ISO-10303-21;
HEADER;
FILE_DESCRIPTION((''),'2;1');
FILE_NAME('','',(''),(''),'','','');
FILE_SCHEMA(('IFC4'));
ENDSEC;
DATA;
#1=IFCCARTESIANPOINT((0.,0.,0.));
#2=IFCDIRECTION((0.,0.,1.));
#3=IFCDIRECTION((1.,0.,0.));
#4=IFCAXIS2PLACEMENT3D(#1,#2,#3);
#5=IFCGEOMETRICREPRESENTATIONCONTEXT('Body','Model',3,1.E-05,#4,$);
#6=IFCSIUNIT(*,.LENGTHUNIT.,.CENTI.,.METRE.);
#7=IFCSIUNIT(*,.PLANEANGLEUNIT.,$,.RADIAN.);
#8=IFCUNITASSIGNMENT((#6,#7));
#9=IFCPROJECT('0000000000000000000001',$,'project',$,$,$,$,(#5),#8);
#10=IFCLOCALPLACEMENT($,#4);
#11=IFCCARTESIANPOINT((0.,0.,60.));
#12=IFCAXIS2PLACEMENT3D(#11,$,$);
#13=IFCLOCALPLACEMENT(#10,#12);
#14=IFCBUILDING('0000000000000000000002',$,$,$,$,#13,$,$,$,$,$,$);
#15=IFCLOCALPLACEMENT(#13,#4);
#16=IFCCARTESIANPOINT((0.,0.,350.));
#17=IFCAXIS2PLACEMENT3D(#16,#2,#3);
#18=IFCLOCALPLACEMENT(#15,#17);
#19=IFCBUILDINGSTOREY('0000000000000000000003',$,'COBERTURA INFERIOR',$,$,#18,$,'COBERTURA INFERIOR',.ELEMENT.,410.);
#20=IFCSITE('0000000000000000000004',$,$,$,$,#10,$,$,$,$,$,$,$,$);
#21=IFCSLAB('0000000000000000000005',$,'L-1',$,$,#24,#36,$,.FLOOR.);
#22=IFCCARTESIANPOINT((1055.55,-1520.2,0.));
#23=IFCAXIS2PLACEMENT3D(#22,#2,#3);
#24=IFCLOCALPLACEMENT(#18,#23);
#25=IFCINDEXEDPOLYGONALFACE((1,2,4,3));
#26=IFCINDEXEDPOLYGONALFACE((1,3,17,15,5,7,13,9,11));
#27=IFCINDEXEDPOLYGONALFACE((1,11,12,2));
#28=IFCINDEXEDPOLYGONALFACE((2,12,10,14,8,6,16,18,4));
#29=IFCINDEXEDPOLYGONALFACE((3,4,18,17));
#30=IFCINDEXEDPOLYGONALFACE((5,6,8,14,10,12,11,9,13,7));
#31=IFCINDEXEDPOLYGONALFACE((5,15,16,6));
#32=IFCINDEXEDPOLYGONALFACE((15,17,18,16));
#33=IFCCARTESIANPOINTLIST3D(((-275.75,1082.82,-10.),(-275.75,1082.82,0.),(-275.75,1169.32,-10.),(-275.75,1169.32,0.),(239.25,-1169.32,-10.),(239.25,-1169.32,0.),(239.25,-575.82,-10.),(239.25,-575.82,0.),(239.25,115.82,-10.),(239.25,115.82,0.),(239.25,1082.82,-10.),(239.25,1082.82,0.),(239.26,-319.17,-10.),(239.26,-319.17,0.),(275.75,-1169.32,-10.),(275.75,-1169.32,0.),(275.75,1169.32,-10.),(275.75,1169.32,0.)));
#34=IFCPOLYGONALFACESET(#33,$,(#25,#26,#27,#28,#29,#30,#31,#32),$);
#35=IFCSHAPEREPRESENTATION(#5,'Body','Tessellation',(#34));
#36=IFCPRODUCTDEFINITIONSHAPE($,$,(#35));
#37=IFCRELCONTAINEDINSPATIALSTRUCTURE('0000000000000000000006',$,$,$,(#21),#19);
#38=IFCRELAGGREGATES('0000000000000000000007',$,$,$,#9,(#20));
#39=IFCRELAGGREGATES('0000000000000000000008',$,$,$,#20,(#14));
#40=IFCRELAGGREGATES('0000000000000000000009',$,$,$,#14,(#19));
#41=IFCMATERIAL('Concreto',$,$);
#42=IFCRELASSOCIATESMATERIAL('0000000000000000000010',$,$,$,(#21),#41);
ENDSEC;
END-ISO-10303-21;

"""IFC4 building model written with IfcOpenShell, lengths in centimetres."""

from ifc_helpers import new_model, si_unit, frame, origin_with_axes, place, context, project, spatial, polyline, outline, extrude, material, element, save


model = new_model("IFC4")

# Units and contexts
model_context = context("Model", 3, precision=1e-05, world=origin_with_axes(), identifier="Body")
ifc_project = project(units=[si_unit("LENGTHUNIT", "METRE", prefix="CENTI"), si_unit("PLANEANGLEUNIT", "RADIAN")], contexts=[model_context])

# Site, building, storey
site_placement = place(None, origin_with_axes())
site = spatial("IfcSite", under=ifc_project, at=site_placement)
building_placement = place(site_placement, frame((0.0, 0.0, 60.0)))
building = spatial("IfcBuilding", under=site, at=building_placement)
placement = place(building_placement, origin_with_axes())
storey_placement = place(placement, frame((0.0, 0.0, 350.0), z_axis=(0.0, 0.0, 1.0), x_axis=(1.0, 0.0, 0.0)))
storey = spatial("IfcBuildingStorey", under=building, at=storey_placement, Name="COBERTURA INFERIOR", LongName="COBERTURA INFERIOR", CompositionType="ELEMENT", Elevation=410.0)

# Shared definitions
ifc_material = material(Name="Concreto")

# Slab
slab_1_placement = place(storey_placement, frame((1055.55, -1520.2, 0.0), z_axis=(0.0, 0.0, 1.0), x_axis=(1.0, 0.0, 0.0)))
element("IfcSlab", 1, at=slab_1_placement, inside=storey, material=ifc_material, Name="L-1", PredefinedType="FLOOR", context=model_context, shape_type="SolidModel", body=[
    extrude(outline(polyline([(275.75, 1169.33), (-275.75, 1169.33), (-275.75, 1082.82), (239.25, 1082.83), (239.25, 115.82), (239.26, -319.18), (239.25, -575.83), (239.25, -1169.33), (275.75, -1169.33), (275.75, 1169.33), (275.75, 1169.33)])), frame((0.0, 0.0, -10.0), z_axis=(0.0, 0.0, 1.0), x_axis=(1.0, 0.0, 0.0)), (0.0, 0.0, 1.0), 10.0),
])

save(model, "model.ifc")
